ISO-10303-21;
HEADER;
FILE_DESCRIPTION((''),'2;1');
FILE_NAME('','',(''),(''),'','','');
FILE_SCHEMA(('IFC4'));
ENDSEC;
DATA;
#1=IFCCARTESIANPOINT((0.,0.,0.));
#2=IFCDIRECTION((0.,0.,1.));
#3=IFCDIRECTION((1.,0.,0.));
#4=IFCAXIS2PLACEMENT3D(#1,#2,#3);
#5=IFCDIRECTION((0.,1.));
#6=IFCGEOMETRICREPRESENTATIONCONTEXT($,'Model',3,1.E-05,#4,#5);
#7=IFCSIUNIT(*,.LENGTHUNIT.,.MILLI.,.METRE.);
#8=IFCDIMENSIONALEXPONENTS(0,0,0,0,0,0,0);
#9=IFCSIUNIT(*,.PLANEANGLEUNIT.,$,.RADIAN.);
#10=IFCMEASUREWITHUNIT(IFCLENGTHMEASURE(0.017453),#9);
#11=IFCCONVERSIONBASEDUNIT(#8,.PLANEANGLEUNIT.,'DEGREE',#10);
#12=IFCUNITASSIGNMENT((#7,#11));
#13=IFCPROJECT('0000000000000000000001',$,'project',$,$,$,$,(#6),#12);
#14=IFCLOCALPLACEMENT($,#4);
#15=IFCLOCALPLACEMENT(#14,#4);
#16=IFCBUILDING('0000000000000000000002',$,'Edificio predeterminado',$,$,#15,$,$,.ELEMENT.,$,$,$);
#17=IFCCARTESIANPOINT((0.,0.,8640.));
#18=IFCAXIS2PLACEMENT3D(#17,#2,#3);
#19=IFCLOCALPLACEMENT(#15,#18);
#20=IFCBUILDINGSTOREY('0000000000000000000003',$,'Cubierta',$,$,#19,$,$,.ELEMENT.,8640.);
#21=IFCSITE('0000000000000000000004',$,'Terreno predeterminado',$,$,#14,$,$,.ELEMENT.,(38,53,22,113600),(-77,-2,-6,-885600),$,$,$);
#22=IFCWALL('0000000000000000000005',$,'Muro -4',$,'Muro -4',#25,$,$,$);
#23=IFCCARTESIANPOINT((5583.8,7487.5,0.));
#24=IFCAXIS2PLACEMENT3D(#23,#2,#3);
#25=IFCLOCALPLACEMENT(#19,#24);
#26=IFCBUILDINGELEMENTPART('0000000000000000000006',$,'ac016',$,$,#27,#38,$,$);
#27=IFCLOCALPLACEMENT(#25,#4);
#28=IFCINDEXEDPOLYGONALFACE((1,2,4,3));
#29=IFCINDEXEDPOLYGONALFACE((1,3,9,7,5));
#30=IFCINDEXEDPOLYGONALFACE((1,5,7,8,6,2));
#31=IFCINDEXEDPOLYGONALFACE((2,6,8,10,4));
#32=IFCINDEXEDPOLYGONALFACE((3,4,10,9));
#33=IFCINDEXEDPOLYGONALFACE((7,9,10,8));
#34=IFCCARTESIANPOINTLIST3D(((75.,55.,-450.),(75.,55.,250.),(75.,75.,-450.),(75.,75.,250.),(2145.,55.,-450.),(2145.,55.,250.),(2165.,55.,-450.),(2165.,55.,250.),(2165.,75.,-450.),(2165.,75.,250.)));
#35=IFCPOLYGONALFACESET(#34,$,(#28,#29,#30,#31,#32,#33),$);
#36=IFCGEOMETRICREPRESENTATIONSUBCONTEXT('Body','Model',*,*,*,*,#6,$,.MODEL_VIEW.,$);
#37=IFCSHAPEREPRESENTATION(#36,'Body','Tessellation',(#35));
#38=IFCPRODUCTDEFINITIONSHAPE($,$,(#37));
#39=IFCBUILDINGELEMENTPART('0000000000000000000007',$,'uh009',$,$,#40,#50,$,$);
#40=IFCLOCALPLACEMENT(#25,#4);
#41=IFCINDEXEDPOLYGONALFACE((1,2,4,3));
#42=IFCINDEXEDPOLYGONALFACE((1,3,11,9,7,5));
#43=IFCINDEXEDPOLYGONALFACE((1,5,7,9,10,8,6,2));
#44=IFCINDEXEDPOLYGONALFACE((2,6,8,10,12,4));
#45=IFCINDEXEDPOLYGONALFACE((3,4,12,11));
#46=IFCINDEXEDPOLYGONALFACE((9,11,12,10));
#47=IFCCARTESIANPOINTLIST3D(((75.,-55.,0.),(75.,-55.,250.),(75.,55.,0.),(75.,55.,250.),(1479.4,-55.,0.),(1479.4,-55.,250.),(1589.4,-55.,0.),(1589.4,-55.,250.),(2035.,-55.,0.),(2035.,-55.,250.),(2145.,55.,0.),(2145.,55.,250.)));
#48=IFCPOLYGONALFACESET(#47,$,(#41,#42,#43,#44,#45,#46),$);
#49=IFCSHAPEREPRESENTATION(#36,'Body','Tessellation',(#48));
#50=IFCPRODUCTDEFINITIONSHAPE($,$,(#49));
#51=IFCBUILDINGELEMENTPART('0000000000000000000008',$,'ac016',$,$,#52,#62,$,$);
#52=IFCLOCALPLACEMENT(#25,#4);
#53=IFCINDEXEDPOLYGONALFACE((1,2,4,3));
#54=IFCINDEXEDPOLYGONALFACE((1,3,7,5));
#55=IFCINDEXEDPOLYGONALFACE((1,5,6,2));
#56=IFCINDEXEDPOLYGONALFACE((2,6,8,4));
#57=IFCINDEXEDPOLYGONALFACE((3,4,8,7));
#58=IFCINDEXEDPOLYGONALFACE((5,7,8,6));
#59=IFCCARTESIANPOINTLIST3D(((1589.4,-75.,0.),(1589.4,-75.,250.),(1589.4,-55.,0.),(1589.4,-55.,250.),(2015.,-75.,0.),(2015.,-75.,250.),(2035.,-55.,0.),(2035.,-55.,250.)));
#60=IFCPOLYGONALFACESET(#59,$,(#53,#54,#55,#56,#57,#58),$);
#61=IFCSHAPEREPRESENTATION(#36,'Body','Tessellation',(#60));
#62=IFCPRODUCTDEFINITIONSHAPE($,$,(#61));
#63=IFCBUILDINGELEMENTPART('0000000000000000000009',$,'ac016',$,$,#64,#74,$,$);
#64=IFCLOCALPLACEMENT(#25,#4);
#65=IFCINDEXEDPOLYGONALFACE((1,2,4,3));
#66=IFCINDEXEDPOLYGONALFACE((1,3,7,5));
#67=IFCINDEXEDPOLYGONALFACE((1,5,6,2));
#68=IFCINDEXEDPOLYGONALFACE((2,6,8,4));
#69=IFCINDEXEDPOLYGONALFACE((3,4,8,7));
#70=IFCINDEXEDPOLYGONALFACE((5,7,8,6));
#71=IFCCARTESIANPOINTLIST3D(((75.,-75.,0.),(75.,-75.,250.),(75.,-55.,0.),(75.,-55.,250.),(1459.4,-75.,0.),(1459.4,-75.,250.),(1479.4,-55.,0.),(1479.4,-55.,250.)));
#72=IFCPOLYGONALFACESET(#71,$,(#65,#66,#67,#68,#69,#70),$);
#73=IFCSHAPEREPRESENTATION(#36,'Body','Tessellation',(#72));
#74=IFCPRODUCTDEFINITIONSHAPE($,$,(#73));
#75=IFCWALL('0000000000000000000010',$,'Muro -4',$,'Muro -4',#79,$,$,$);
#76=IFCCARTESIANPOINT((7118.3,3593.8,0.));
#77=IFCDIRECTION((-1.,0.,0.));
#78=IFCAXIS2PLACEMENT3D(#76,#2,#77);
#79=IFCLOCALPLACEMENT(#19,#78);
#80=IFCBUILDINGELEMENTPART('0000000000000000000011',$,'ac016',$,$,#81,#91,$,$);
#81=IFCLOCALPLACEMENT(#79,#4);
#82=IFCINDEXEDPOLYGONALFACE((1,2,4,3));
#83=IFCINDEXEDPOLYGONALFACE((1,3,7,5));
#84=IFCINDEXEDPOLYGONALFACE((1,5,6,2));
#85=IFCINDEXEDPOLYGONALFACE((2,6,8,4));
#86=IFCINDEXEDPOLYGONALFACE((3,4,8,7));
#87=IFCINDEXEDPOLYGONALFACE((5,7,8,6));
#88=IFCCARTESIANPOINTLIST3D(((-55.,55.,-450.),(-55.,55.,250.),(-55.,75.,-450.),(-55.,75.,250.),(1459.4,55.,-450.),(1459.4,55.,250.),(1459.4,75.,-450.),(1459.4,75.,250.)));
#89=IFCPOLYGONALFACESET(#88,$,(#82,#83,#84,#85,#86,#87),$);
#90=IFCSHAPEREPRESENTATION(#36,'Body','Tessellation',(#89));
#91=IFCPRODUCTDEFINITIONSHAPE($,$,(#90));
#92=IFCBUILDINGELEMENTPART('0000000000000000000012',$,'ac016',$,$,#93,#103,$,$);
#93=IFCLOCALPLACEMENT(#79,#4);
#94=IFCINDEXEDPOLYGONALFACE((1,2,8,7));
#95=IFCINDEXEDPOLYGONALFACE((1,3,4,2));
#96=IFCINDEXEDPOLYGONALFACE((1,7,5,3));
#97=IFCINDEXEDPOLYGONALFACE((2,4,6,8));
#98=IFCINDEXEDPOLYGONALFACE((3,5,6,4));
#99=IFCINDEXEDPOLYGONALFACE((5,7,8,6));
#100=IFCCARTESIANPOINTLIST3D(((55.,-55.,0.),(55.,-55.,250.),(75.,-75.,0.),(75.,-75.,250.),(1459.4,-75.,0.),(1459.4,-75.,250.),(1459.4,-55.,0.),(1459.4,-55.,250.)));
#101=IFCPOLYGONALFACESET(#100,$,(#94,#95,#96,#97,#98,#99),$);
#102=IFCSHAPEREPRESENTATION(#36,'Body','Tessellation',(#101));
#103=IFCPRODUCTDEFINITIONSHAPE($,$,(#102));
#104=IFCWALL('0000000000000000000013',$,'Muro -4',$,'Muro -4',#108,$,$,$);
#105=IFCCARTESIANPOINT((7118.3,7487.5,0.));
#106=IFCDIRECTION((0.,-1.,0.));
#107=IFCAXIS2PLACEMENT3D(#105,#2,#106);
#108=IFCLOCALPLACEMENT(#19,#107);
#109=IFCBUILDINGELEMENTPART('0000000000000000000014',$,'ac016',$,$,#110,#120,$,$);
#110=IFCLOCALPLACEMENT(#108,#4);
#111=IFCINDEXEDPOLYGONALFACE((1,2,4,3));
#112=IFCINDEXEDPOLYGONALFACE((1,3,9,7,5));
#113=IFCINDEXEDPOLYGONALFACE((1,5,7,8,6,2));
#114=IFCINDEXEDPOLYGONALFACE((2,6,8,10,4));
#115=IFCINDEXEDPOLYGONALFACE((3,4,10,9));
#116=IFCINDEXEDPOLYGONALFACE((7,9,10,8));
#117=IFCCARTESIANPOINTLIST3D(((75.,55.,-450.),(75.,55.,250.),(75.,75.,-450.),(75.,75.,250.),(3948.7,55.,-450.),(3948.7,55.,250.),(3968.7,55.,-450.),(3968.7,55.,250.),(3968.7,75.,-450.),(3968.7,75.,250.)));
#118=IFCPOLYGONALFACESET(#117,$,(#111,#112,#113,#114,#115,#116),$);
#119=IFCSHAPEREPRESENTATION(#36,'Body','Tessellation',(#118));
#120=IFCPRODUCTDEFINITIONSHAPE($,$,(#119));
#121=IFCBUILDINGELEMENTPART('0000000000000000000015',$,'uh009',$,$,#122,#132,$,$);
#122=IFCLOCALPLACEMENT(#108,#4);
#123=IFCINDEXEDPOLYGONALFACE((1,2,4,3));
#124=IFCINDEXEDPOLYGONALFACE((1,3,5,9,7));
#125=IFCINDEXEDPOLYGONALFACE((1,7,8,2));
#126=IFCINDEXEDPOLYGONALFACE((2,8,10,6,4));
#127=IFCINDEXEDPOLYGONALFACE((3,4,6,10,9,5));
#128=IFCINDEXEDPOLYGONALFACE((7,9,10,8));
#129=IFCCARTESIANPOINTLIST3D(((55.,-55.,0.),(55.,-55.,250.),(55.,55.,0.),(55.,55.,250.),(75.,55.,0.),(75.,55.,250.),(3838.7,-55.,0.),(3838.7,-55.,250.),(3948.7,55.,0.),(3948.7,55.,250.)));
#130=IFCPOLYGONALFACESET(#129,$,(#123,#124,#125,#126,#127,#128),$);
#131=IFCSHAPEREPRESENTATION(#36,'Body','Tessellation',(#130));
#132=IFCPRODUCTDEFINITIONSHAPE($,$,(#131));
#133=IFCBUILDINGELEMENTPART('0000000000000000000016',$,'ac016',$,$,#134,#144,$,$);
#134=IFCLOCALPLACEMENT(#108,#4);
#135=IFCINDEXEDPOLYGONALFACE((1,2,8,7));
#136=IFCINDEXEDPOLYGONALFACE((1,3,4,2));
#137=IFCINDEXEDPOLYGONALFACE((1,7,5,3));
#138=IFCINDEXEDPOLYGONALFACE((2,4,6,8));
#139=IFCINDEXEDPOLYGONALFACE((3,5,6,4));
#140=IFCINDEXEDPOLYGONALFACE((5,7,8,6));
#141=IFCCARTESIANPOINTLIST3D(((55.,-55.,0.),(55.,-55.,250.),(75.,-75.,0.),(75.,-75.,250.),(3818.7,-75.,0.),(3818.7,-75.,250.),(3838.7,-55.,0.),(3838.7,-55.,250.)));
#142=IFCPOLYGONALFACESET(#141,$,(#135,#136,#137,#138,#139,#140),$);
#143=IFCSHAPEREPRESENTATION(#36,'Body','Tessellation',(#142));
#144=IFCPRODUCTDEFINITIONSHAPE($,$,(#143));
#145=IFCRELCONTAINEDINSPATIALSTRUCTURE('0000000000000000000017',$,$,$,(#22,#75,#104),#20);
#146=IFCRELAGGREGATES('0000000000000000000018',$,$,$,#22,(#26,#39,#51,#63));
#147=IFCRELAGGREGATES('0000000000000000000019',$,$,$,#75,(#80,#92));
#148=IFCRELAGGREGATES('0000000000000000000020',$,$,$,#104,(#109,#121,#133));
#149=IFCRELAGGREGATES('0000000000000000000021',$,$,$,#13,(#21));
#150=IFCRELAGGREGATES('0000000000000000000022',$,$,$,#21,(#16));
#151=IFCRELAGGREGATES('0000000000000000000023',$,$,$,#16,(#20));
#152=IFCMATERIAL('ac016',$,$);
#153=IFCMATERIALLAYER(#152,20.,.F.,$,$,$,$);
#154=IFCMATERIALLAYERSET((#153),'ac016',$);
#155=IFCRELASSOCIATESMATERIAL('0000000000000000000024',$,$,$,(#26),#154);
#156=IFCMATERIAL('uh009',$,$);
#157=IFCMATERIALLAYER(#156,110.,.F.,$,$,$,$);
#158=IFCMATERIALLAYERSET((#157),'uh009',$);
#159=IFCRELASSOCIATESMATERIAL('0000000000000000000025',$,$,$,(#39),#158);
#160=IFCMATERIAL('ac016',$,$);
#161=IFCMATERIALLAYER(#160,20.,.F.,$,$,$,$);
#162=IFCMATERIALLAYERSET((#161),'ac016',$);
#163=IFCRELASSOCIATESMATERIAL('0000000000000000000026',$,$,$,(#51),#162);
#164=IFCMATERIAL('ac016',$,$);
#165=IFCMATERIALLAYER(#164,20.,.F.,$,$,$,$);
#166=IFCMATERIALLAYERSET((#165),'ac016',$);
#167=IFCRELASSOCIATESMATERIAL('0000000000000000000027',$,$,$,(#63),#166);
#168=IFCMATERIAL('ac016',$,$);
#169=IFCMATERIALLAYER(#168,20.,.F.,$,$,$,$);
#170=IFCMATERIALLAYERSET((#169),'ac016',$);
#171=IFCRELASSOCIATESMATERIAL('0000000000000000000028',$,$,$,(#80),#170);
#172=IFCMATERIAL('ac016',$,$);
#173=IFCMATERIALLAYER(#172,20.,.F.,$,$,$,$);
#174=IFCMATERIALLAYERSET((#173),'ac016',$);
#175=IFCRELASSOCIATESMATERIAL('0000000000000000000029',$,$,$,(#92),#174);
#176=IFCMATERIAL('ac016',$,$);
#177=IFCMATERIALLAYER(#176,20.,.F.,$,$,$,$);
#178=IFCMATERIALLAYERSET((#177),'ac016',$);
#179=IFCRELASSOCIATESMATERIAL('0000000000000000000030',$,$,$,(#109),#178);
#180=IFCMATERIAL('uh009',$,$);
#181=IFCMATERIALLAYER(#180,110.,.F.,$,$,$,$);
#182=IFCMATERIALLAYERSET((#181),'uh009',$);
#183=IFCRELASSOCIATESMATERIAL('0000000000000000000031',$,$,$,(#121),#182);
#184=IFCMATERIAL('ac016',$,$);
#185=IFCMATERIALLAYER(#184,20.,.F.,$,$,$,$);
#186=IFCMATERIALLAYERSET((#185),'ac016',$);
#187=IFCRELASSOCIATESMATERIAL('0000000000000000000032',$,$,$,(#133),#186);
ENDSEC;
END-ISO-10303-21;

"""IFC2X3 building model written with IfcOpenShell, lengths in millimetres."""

from ifc_helpers import new_model, entity, si_unit, converted_unit, direction, frame, origin_with_axes, place, context, subcontext, project, spatial, polyline, outline, extrude, material, layer, layer_set, layer_usage, element, aggregate, save


model = new_model("IFC2X3")

# Units and contexts
model_context = context("Model", 3, precision=1e-05, world=origin_with_axes(), true_north=direction((0.0, 1.0)))
body_context = subcontext(model_context, "Body", "Model", "MODEL_VIEW")
ifc_project = project(units=[si_unit("LENGTHUNIT", "METRE", prefix="MILLI"), converted_unit("PLANEANGLEUNIT", "DEGREE", entity("IfcLengthMeasure", 0.017453), si_unit("PLANEANGLEUNIT", "RADIAN"), dimensions=[0, 0, 0, 0, 0, 0, 0])], contexts=[model_context])

# Site, building, storey
site_placement = place(None, origin_with_axes())
site = spatial("IfcSite", under=ifc_project, at=site_placement, Name="Terreno predeterminado", CompositionType="ELEMENT", RefLatitude=(38, 53, 22, 113600), RefLongitude=(-77, -2, -6, -885600))
building_placement = place(site_placement, origin_with_axes())
building = spatial("IfcBuilding", under=site, at=building_placement, Name="Edificio predeterminado", CompositionType="ELEMENT")
storey_placement = place(building_placement, frame((0.0, 0.0, 8640.0), z_axis=(0.0, 0.0, 1.0), x_axis=(1.0, 0.0, 0.0)))
storey = spatial("IfcBuildingStorey", under=building, at=storey_placement, Name="Cubierta", CompositionType="ELEMENT", Elevation=8640.0)

# Walls, building element parts
wall_1_placement = place(storey_placement, frame((5583.8, 7487.5, 0.0), z_axis=(0.0, 0.0, 1.0), x_axis=(1.0, 0.0, 0.0)))
wall_1 = element("IfcWall", 1, at=wall_1_placement, inside=storey, Name="Muro -4", ObjectType="Muro -4")
ifc_material_1 = material(Name="ac016")
ifc_layer_1 = layer(ifc_material_1, 20.0, ventilated=False)
ifc_layer_set_1 = layer_set([ifc_layer_1], Name="ac016")
ifc_layer_usage_1 = layer_usage(ifc_layer_set_1, "AXIS2", "NEGATIVE", -75.0)
building_element_part_1_placement = place(wall_1_placement, origin_with_axes())
building_element_part_1 = element("IfcBuildingElementPart", 2, at=building_element_part_1_placement, material=ifc_layer_usage_1, Name="ac016", context=body_context, shape_type="SweptSolid", body=[
    extrude(outline(polyline([(2165.0, 75.0), (2165.0, 55.0), (2145.0, 55.0), (75.0, 55.0), (75.0, 75.0), (2165.0, 75.0)])), frame((0.0, 0.0, -450.0), z_axis=(0.0, 0.0, 1.0), x_axis=(1.0, 0.0, 0.0)), (0.0, 0.0, 1.0), 700.0),
])
ifc_material_2 = material(Name="uh009")
ifc_layer_2 = layer(ifc_material_2, 110.0, ventilated=False)
ifc_layer_set_2 = layer_set([ifc_layer_2], Name="uh009")
ifc_layer_usage_2 = layer_usage(ifc_layer_set_2, "AXIS2", "NEGATIVE", -55.0)
building_element_part_2_placement = place(wall_1_placement, origin_with_axes())
building_element_part_2 = element("IfcBuildingElementPart", 3, at=building_element_part_2_placement, material=ifc_layer_usage_2, Name="uh009", context=body_context, shape_type="SweptSolid", body=[
    extrude(outline(polyline([(2145.0, 55.0), (2035.0, -55.0), (1589.4, -55.0), (1479.4, -55.0), (75.0, -55.0), (75.0, 55.0), (2145.0, 55.0)])), origin_with_axes(), (0.0, 0.0, 1.0), 250.0),
])
ifc_material_3 = material(Name="ac016")
ifc_layer_3 = layer(ifc_material_3, 20.0, ventilated=False)
ifc_layer_set_3 = layer_set([ifc_layer_3], Name="ac016")
ifc_layer_usage_3 = layer_usage(ifc_layer_set_3, "AXIS2", "NEGATIVE", 55.0)
building_element_part_3_placement = place(wall_1_placement, origin_with_axes())
building_element_part_3 = element("IfcBuildingElementPart", 4, at=building_element_part_3_placement, material=ifc_layer_usage_3, Name="ac016", context=body_context, shape_type="SweptSolid", body=[
    extrude(outline(polyline([(1589.4, -55.0), (2035.0, -55.0), (2015.0, -75.0), (1589.4, -75.0), (1589.4, -55.0)])), origin_with_axes(), (0.0, 0.0, 1.0), 250.0),
])
ifc_material_4 = material(Name="ac016")
ifc_layer_4 = layer(ifc_material_4, 20.0, ventilated=False)
ifc_layer_set_4 = layer_set([ifc_layer_4], Name="ac016")
ifc_layer_usage_4 = layer_usage(ifc_layer_set_4, "AXIS2", "NEGATIVE", 55.0)
building_element_part_4_placement = place(wall_1_placement, origin_with_axes())
building_element_part_4 = element("IfcBuildingElementPart", 5, at=building_element_part_4_placement, material=ifc_layer_usage_4, Name="ac016", context=body_context, shape_type="SweptSolid", body=[
    extrude(outline(polyline([(1479.4, -55.0), (1459.4, -75.0), (75.0, -75.0), (75.0, -55.0), (1479.4, -55.0)])), origin_with_axes(), (0.0, 0.0, 1.0), 250.0),
])
aggregate(wall_1, [building_element_part_1, building_element_part_2, building_element_part_3, building_element_part_4])
wall_2_placement = place(storey_placement, frame((7118.3, 3593.8, 0.0), z_axis=(0.0, 0.0, 1.0), x_axis=(-1.0, 0.0, 0.0)))
wall_2 = element("IfcWall", 6, at=wall_2_placement, inside=storey, Name="Muro -4", ObjectType="Muro -4")
ifc_material_5 = material(Name="ac016")
ifc_layer_5 = layer(ifc_material_5, 20.0, ventilated=False)
ifc_layer_set_5 = layer_set([ifc_layer_5], Name="ac016")
ifc_layer_usage_5 = layer_usage(ifc_layer_set_5, "AXIS2", "NEGATIVE", -75.0)
building_element_part_5_placement = place(wall_2_placement, origin_with_axes())
building_element_part_5 = element("IfcBuildingElementPart", 7, at=building_element_part_5_placement, material=ifc_layer_usage_5, Name="ac016", context=body_context, shape_type="SweptSolid", body=[
    extrude(outline(polyline([(1459.4, 75.0), (1459.4, 55.0), (-55.0, 55.0), (-55.0, 75.0), (1459.4, 75.0)])), frame((0.0, 0.0, -450.0), z_axis=(0.0, 0.0, 1.0), x_axis=(1.0, 0.0, 0.0)), (0.0, 0.0, 1.0), 700.0),
])
ifc_material_6 = material(Name="ac016")
ifc_layer_6 = layer(ifc_material_6, 20.0, ventilated=False)
ifc_layer_set_6 = layer_set([ifc_layer_6], Name="ac016")
ifc_layer_usage_6 = layer_usage(ifc_layer_set_6, "AXIS2", "NEGATIVE", 55.0)
building_element_part_6_placement = place(wall_2_placement, origin_with_axes())
building_element_part_6 = element("IfcBuildingElementPart", 8, at=building_element_part_6_placement, material=ifc_layer_usage_6, Name="ac016", context=body_context, shape_type="SweptSolid", body=[
    extrude(outline(polyline([(1459.4, -55.0), (1459.4, -75.0), (75.0, -75.0), (55.0, -55.0), (1459.4, -55.0)])), origin_with_axes(), (0.0, 0.0, 1.0), 250.0),
])
aggregate(wall_2, [building_element_part_5, building_element_part_6])
wall_3_placement = place(storey_placement, frame((7118.3, 7487.5, 0.0), z_axis=(0.0, 0.0, 1.0), x_axis=(0.0, -1.0, 0.0)))
wall_3 = element("IfcWall", 9, at=wall_3_placement, inside=storey, Name="Muro -4", ObjectType="Muro -4")
ifc_material_7 = material(Name="ac016")
ifc_layer_7 = layer(ifc_material_7, 20.0, ventilated=False)
ifc_layer_set_7 = layer_set([ifc_layer_7], Name="ac016")
ifc_layer_usage_7 = layer_usage(ifc_layer_set_7, "AXIS2", "NEGATIVE", -75.0)
building_element_part_7_placement = place(wall_3_placement, origin_with_axes())
building_element_part_7 = element("IfcBuildingElementPart", 10, at=building_element_part_7_placement, material=ifc_layer_usage_7, Name="ac016", context=body_context, shape_type="SweptSolid", body=[
    extrude(outline(polyline([(3968.7, 75.0), (3968.7, 55.0), (3948.7, 55.0), (75.0, 55.0), (75.0, 75.0), (3968.7, 75.0)])), frame((0.0, 0.0, -450.0), z_axis=(0.0, 0.0, 1.0), x_axis=(1.0, 0.0, 0.0)), (0.0, 0.0, 1.0), 700.0),
])
ifc_material_8 = material(Name="uh009")
ifc_layer_8 = layer(ifc_material_8, 110.0, ventilated=False)
ifc_layer_set_8 = layer_set([ifc_layer_8], Name="uh009")
ifc_layer_usage_8 = layer_usage(ifc_layer_set_8, "AXIS2", "NEGATIVE", -55.0)
building_element_part_8_placement = place(wall_3_placement, origin_with_axes())
building_element_part_8 = element("IfcBuildingElementPart", 11, at=building_element_part_8_placement, material=ifc_layer_usage_8, Name="uh009", context=body_context, shape_type="SweptSolid", body=[
    extrude(outline(polyline([(3948.7, 55.0), (3838.7, -55.0), (55.0, -55.0), (55.0, 55.0), (75.0, 55.0), (3948.7, 55.0)])), origin_with_axes(), (0.0, 0.0, 1.0), 250.0),
])
ifc_material_9 = material(Name="ac016")
ifc_layer_9 = layer(ifc_material_9, 20.0, ventilated=False)
ifc_layer_set_9 = layer_set([ifc_layer_9], Name="ac016")
ifc_layer_usage_9 = layer_usage(ifc_layer_set_9, "AXIS2", "NEGATIVE", 55.0)
building_element_part_9_placement = place(wall_3_placement, origin_with_axes())
building_element_part_9 = element("IfcBuildingElementPart", 12, at=building_element_part_9_placement, material=ifc_layer_usage_9, Name="ac016", context=body_context, shape_type="SweptSolid", body=[
    extrude(outline(polyline([(3838.7, -55.0), (3818.7, -75.0), (75.0, -75.0), (55.0, -55.0), (3838.7, -55.0)])), origin_with_axes(), (0.0, 0.0, 1.0), 250.0),
])
aggregate(wall_3, [building_element_part_7, building_element_part_8, building_element_part_9])

save(model, "model.ifc")
